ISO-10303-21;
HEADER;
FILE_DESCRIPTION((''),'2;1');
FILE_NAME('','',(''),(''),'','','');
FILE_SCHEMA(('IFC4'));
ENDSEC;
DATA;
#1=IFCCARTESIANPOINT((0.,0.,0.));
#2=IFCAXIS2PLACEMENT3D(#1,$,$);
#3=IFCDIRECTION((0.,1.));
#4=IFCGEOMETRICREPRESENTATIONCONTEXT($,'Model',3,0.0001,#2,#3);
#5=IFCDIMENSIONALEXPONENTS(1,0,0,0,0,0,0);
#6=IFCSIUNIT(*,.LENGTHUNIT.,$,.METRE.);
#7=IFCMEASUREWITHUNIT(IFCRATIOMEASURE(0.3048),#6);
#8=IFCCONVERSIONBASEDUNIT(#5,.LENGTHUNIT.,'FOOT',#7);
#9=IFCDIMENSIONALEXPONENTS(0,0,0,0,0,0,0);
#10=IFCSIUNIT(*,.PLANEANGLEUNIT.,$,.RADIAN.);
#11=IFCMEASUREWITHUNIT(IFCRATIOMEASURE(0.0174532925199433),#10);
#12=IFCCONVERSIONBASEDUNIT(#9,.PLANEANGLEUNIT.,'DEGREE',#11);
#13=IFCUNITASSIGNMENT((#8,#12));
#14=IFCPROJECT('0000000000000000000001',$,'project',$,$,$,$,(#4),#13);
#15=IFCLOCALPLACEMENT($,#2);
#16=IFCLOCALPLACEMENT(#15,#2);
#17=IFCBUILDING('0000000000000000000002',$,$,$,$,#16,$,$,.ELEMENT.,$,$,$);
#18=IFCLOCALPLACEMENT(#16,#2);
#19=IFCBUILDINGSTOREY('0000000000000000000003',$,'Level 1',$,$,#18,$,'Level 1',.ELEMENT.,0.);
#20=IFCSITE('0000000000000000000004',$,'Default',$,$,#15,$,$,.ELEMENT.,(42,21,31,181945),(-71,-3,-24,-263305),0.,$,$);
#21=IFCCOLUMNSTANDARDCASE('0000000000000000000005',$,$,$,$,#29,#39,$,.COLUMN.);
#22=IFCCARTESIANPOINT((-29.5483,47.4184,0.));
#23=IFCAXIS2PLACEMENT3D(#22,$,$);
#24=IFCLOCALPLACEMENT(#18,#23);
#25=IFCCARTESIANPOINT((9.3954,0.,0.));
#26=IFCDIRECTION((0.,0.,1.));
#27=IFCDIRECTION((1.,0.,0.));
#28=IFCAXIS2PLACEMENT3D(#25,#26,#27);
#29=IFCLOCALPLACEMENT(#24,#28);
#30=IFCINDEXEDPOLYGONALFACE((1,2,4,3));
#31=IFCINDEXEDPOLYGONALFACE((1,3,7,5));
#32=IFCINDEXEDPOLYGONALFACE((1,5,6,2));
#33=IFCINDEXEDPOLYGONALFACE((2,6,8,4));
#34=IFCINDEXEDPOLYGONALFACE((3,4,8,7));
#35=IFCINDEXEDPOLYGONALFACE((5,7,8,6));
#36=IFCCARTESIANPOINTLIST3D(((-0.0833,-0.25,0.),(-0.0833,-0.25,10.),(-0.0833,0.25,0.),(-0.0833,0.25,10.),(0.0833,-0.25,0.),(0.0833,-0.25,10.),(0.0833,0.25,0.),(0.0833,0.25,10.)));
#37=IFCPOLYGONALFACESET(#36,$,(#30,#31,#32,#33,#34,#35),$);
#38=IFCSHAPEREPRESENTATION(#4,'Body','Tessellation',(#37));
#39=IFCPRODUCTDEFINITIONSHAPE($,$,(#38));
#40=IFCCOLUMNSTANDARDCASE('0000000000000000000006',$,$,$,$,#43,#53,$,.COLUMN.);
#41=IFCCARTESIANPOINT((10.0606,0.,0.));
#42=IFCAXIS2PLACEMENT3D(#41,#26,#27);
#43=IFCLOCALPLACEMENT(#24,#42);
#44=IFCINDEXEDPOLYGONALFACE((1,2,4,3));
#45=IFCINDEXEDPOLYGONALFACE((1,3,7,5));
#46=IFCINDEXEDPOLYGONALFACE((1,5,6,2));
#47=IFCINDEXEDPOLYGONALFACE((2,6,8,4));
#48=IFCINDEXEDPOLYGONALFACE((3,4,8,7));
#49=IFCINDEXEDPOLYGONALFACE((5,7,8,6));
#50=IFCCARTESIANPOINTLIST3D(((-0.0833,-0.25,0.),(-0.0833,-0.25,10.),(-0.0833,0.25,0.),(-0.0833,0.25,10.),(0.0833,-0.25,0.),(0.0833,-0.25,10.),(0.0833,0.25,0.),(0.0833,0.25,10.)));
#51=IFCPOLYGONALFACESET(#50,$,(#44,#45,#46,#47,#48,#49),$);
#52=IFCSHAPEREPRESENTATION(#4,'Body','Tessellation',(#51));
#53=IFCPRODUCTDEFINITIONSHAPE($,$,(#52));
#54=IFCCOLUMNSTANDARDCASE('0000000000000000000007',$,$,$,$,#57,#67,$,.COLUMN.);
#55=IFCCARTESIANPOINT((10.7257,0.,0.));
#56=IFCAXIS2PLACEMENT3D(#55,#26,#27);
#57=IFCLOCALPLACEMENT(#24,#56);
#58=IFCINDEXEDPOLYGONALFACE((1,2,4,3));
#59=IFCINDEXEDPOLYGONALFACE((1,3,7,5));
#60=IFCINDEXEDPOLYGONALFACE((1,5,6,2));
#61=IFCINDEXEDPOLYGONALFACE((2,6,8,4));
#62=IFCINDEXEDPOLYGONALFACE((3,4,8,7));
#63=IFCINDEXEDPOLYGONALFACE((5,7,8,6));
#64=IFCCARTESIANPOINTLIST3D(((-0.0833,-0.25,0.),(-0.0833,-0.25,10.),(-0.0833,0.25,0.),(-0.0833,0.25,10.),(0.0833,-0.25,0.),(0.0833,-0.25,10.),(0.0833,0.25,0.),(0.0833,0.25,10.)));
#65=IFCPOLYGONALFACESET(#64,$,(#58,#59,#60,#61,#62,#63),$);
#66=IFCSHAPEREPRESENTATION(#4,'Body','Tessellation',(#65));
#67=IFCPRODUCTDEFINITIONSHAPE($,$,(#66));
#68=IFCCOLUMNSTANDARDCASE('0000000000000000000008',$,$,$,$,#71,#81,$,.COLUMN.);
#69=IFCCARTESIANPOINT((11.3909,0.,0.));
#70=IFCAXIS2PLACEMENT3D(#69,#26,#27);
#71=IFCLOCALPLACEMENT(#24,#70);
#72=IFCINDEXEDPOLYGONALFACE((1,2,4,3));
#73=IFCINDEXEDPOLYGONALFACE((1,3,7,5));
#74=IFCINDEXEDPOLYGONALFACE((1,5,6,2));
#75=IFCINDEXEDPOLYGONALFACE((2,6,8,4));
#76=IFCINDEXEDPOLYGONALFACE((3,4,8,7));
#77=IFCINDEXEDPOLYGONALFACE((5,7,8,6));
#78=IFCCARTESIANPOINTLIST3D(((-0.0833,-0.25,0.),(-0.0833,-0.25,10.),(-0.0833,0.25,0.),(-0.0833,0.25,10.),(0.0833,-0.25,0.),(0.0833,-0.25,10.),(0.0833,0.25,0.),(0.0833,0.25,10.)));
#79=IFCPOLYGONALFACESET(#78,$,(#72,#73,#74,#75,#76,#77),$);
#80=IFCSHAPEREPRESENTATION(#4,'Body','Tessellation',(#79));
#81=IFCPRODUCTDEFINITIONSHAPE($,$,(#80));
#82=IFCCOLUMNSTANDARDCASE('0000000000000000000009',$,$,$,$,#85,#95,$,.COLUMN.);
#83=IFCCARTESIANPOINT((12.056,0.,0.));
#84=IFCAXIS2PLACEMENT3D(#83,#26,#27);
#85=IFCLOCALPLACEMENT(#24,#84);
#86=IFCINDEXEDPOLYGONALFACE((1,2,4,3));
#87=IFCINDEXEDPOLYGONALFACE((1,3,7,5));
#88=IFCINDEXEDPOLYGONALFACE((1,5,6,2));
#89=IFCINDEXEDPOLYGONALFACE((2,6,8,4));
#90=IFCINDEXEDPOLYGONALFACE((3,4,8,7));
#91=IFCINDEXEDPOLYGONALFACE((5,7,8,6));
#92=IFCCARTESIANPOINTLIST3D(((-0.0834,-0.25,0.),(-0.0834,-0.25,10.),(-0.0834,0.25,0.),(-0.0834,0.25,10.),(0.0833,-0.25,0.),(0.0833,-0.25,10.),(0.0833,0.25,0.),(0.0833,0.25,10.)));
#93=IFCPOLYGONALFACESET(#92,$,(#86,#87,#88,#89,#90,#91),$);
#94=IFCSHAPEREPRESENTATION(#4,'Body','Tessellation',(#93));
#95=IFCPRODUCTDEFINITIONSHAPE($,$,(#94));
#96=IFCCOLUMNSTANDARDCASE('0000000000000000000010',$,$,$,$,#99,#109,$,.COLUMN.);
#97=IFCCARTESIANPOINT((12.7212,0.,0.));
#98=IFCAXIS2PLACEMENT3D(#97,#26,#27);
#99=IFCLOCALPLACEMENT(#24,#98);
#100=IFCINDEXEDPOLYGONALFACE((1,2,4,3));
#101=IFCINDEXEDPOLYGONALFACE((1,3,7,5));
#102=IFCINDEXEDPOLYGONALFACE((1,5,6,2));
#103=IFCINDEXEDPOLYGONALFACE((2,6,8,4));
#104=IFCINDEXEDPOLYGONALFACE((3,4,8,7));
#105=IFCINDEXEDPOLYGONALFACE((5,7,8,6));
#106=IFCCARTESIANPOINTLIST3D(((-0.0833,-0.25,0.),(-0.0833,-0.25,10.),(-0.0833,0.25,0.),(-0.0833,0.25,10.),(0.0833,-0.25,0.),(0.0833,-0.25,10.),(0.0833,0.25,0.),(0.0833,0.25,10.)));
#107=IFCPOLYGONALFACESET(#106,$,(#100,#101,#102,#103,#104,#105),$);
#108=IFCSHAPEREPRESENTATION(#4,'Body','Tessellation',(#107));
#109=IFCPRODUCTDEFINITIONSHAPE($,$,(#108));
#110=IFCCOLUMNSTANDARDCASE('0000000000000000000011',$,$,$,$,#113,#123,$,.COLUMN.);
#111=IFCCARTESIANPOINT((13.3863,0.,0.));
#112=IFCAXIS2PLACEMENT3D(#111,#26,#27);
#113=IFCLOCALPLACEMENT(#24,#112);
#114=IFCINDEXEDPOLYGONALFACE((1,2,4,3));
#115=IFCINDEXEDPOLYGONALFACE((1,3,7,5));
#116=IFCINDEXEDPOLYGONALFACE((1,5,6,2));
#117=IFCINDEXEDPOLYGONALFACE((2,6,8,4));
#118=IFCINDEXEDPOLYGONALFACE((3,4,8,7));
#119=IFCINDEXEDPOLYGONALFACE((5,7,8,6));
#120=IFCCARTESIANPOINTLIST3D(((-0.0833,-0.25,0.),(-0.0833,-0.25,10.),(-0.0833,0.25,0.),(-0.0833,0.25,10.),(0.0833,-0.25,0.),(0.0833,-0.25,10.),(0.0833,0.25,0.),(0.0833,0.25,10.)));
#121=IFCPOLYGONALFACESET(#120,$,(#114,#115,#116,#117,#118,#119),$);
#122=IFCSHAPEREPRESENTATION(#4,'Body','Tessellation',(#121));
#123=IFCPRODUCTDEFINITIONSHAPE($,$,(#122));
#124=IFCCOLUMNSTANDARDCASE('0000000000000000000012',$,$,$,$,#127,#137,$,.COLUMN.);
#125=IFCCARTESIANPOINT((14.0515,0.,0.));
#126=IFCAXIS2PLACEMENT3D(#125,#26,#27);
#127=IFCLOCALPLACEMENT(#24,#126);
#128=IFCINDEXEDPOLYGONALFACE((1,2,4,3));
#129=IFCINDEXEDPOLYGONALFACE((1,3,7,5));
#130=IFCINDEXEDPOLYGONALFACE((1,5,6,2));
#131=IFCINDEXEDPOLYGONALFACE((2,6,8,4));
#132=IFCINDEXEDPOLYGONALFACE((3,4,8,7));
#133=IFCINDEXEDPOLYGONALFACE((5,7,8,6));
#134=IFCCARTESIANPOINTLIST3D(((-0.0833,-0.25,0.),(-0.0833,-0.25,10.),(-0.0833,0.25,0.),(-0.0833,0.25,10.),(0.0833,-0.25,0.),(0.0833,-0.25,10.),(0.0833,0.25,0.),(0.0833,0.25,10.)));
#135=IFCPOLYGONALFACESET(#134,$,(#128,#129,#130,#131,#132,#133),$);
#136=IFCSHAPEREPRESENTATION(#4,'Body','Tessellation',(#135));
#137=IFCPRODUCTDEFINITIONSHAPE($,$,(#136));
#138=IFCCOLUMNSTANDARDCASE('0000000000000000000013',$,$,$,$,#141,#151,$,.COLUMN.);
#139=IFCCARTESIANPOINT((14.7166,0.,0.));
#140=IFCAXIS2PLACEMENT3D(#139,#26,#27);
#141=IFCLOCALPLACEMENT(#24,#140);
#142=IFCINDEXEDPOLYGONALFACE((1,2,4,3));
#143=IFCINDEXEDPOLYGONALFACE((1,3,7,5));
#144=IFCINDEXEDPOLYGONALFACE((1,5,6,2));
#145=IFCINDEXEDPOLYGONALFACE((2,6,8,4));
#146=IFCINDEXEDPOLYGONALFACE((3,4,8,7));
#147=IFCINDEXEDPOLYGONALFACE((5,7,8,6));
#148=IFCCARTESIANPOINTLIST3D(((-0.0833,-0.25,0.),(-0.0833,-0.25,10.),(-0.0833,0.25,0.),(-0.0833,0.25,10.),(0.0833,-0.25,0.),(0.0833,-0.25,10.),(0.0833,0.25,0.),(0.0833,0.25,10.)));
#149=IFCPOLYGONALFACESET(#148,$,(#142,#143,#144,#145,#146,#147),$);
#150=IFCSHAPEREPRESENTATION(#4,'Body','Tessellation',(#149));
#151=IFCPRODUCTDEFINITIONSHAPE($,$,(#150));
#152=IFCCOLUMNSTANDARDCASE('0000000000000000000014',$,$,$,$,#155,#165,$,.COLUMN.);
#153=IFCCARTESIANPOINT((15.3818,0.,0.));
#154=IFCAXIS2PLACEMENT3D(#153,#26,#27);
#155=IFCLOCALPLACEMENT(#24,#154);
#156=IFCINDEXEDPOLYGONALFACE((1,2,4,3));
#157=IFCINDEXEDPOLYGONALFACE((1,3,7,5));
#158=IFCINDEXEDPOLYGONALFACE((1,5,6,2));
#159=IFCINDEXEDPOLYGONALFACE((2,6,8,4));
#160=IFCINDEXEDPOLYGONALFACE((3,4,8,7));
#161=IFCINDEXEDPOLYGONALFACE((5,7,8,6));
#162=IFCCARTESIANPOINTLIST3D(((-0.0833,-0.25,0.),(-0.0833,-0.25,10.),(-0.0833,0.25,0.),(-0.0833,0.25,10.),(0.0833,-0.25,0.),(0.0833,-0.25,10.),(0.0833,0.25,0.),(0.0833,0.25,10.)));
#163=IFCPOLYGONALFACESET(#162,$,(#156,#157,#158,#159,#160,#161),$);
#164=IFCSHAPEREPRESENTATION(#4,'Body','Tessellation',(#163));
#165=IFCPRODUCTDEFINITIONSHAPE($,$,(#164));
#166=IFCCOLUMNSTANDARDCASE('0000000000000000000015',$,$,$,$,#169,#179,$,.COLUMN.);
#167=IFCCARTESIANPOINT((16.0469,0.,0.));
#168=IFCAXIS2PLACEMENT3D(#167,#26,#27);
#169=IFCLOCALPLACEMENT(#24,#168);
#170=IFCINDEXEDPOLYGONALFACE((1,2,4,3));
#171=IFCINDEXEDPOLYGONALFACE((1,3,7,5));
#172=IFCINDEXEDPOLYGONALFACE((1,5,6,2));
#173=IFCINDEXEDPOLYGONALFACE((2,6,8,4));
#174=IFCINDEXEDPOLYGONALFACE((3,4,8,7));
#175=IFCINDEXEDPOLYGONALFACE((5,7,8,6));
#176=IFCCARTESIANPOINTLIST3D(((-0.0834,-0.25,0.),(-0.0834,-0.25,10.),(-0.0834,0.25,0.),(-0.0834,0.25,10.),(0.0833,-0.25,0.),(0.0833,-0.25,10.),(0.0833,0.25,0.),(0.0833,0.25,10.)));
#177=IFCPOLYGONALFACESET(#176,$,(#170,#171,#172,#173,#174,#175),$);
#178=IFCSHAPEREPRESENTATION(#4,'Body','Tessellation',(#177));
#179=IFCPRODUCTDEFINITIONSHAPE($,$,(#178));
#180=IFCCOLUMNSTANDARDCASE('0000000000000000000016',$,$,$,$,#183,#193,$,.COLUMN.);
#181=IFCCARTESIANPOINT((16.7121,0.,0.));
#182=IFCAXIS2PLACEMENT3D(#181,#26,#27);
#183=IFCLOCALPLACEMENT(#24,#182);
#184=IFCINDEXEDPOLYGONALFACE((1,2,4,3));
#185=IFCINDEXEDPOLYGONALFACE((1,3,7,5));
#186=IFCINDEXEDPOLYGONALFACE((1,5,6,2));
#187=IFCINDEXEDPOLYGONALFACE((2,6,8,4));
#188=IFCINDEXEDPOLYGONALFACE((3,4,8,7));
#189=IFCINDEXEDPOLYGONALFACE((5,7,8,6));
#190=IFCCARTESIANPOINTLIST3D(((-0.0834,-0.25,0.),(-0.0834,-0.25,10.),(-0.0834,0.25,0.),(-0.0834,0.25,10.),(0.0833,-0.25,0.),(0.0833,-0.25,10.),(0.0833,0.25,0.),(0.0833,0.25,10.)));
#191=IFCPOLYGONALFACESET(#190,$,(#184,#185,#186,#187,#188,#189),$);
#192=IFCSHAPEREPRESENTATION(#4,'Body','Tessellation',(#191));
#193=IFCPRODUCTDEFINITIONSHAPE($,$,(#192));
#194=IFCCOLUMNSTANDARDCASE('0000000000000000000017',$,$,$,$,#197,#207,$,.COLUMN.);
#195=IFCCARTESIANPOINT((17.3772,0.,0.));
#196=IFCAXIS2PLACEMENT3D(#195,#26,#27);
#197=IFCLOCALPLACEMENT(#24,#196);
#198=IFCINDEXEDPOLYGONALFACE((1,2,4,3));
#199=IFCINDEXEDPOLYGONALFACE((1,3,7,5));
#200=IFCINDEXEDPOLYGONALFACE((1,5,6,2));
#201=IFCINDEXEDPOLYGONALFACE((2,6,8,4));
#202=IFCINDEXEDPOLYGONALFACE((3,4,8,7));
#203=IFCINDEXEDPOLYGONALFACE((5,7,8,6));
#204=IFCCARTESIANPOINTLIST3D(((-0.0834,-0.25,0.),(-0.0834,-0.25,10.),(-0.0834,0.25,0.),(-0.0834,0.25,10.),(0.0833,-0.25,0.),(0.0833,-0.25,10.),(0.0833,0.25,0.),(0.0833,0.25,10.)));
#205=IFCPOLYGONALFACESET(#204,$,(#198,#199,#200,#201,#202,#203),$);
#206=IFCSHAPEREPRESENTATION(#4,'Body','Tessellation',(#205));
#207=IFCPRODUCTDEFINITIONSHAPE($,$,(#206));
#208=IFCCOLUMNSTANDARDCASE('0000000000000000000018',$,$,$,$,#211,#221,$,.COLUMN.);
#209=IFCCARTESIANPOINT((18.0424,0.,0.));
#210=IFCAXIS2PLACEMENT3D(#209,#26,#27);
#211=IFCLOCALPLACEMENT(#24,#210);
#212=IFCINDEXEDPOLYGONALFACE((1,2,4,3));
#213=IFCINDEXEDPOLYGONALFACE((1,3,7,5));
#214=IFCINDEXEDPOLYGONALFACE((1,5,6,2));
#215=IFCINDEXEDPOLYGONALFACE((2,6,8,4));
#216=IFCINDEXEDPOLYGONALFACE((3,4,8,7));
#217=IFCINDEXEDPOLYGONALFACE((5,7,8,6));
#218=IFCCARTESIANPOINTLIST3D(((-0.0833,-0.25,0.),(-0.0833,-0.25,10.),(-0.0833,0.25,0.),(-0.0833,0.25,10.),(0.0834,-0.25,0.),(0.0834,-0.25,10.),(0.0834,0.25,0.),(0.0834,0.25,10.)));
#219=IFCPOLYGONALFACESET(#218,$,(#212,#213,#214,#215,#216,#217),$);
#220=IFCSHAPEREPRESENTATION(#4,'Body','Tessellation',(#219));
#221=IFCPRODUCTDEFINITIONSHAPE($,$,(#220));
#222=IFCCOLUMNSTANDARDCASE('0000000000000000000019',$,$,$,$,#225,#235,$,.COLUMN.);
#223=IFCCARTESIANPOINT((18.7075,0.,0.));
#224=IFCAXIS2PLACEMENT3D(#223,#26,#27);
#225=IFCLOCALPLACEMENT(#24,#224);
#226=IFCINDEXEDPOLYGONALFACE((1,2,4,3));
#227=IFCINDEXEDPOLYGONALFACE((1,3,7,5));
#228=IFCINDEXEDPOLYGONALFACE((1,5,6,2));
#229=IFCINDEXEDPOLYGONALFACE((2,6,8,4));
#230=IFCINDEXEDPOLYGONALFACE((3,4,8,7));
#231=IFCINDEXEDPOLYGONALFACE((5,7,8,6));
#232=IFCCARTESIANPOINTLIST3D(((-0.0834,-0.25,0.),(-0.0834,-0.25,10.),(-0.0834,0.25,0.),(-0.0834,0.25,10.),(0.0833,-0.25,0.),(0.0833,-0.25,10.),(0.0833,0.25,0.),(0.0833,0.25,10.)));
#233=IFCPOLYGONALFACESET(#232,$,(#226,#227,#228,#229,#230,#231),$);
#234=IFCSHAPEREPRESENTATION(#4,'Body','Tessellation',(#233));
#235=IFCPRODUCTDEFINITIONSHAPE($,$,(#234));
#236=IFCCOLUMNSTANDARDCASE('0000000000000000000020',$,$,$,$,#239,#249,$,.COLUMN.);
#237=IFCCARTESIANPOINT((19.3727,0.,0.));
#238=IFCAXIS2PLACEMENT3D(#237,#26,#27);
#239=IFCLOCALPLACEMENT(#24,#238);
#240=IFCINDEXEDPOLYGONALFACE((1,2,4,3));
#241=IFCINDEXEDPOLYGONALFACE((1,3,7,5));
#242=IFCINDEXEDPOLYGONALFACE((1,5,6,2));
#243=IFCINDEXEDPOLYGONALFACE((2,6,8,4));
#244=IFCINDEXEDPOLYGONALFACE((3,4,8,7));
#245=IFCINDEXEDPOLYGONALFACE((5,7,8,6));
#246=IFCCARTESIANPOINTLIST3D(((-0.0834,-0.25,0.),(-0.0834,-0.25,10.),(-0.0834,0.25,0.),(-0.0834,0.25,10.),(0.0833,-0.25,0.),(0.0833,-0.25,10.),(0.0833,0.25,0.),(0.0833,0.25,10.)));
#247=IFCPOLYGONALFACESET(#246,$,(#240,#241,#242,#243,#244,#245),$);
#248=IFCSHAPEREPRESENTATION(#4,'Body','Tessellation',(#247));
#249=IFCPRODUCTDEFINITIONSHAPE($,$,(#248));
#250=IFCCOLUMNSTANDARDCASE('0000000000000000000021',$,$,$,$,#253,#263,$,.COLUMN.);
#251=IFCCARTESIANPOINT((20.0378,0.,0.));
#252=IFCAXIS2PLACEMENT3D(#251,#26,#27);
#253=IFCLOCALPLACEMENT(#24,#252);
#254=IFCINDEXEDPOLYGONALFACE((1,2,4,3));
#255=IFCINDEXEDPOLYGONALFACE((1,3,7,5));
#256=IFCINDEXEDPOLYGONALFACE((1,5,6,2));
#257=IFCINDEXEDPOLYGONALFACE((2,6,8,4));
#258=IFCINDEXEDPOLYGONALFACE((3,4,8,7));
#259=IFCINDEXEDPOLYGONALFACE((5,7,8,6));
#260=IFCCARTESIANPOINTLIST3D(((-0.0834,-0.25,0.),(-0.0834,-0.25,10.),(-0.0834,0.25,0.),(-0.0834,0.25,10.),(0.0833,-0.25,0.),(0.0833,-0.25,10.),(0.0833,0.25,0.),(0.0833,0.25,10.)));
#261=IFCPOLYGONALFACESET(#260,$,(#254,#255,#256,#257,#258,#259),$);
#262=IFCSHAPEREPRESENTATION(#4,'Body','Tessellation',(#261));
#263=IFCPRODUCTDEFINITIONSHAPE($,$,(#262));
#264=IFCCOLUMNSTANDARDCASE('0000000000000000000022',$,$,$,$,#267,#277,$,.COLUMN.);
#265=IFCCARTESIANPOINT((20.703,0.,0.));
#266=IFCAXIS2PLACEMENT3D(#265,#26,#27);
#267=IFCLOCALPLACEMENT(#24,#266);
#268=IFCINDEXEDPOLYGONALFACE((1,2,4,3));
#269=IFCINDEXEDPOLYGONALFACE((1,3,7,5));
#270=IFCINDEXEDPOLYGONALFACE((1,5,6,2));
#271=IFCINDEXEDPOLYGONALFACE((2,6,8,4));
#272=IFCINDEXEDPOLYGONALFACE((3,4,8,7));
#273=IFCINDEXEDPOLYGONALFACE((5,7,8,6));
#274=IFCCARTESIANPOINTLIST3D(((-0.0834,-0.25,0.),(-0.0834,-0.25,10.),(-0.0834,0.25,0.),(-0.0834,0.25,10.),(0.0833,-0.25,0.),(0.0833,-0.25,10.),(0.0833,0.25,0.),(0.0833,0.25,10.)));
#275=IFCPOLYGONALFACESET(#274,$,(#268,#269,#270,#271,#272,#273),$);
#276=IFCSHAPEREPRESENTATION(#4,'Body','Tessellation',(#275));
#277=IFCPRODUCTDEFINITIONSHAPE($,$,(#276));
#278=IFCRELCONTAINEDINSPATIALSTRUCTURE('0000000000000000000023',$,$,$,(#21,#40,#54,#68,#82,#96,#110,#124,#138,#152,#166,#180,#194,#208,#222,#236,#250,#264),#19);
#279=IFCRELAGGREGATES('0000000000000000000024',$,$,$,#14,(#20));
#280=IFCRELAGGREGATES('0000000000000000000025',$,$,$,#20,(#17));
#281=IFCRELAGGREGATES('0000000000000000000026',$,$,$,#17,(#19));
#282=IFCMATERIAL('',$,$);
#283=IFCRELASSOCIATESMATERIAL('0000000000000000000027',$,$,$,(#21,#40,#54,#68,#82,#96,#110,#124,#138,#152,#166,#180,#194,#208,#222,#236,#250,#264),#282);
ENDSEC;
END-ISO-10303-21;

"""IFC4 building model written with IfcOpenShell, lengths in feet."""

from ifc_helpers import new_model, entity, si_unit, converted_unit, direction, frame, origin, place, context, project, spatial, rectangle, extrude, material, element, save


model = new_model("IFC4")

# Units and contexts
model_context = context("Model", 3, precision=0.0001, world=origin(), true_north=direction((0.0, 1.0)))
ifc_project = project(units=[converted_unit("LENGTHUNIT", "FOOT", entity("IfcRatioMeasure", 0.3048), si_unit("LENGTHUNIT", "METRE"), dimensions=[1, 0, 0, 0, 0, 0, 0]), converted_unit("PLANEANGLEUNIT", "DEGREE", entity("IfcRatioMeasure", 0.0174532925199433), si_unit("PLANEANGLEUNIT", "RADIAN"), dimensions=[0, 0, 0, 0, 0, 0, 0])], contexts=[model_context])

# Site, building, storey
site_placement = place(None, origin())
site = spatial("IfcSite", under=ifc_project, at=site_placement, Name="Default", CompositionType="ELEMENT", RefLatitude=(42, 21, 31, 181945), RefLongitude=(-71, -3, -24, -263305), RefElevation=0.0)
building_placement = place(site_placement, origin())
building = spatial("IfcBuilding", under=site, at=building_placement, CompositionType="ELEMENT")
storey_placement = place(building_placement, origin())
storey = spatial("IfcBuildingStorey", under=building, at=storey_placement, Name="Level 1", LongName="Level 1", CompositionType="ELEMENT", Elevation=0.0)

# Columns
ifc_material_1 = material(Name="")
placement = place(storey_placement, frame((-29.5483, 47.4184, 0.0)))
for number, where, z_axis, x_axis in (
    (1, (9.3954, 0.0, 0.0), (0.0, 0.0, 1.0), (1.0, 0.0, 0.0)),
    (2, (10.0606, 0.0, 0.0), (0.0, 0.0, 1.0), (1.0, 0.0, 0.0)),
    (3, (10.7257, 0.0, 0.0), (0.0, 0.0, 1.0), (1.0, 0.0, 0.0)),
    (4, (11.3909, 0.0, 0.0), (0.0, 0.0, 1.0), (1.0, 0.0, 0.0)),
    (5, (12.056, 0.0, 0.0), (0.0, 0.0, 1.0), (1.0, 0.0, 0.0)),
    (6, (12.7212, 0.0, 0.0), (0.0, 0.0, 1.0), (1.0, 0.0, 0.0)),
    (7, (13.3863, 0.0, 0.0), (0.0, 0.0, 1.0), (1.0, 0.0, 0.0)),
    (8, (14.0515, 0.0, 0.0), (0.0, 0.0, 1.0), (1.0, 0.0, 0.0)),
    (9, (14.7166, 0.0, 0.0), (0.0, 0.0, 1.0), (1.0, 0.0, 0.0)),
    (10, (15.3818, 0.0, 0.0), (0.0, 0.0, 1.0), (1.0, 0.0, 0.0)),
    (11, (16.0469, 0.0, 0.0), (0.0, 0.0, 1.0), (1.0, 0.0, 0.0)),
    (12, (16.7121, 0.0, 0.0), (0.0, 0.0, 1.0), (1.0, 0.0, 0.0)),
    (13, (17.3772, 0.0, 0.0), (0.0, 0.0, 1.0), (1.0, 0.0, 0.0)),
    (14, (18.0424, 0.0, 0.0), (0.0, 0.0, 1.0), (1.0, 0.0, 0.0)),
    (15, (18.7075, 0.0, 0.0), (0.0, 0.0, 1.0), (1.0, 0.0, 0.0)),
    (16, (19.3727, 0.0, 0.0), (0.0, 0.0, 1.0), (1.0, 0.0, 0.0)),
    (17, (20.0378, 0.0, 0.0), (0.0, 0.0, 1.0), (1.0, 0.0, 0.0)),
    (18, (20.703, 0.0, 0.0), (0.0, 0.0, 1.0), (1.0, 0.0, 0.0)),
):
    element("IfcColumnStandardCase", number, at=place(placement, frame(where, z_axis=z_axis, x_axis=x_axis)), inside=storey, material=ifc_material_1, PredefinedType="COLUMN", context=model_context, shape_type="SweptSolid", body=[
        extrude(rectangle(XDim=0.1667, YDim=0.5), origin(), (0.0, 0.0, 1.0), 10.0),
    ])

save(model, "model.ifc")
